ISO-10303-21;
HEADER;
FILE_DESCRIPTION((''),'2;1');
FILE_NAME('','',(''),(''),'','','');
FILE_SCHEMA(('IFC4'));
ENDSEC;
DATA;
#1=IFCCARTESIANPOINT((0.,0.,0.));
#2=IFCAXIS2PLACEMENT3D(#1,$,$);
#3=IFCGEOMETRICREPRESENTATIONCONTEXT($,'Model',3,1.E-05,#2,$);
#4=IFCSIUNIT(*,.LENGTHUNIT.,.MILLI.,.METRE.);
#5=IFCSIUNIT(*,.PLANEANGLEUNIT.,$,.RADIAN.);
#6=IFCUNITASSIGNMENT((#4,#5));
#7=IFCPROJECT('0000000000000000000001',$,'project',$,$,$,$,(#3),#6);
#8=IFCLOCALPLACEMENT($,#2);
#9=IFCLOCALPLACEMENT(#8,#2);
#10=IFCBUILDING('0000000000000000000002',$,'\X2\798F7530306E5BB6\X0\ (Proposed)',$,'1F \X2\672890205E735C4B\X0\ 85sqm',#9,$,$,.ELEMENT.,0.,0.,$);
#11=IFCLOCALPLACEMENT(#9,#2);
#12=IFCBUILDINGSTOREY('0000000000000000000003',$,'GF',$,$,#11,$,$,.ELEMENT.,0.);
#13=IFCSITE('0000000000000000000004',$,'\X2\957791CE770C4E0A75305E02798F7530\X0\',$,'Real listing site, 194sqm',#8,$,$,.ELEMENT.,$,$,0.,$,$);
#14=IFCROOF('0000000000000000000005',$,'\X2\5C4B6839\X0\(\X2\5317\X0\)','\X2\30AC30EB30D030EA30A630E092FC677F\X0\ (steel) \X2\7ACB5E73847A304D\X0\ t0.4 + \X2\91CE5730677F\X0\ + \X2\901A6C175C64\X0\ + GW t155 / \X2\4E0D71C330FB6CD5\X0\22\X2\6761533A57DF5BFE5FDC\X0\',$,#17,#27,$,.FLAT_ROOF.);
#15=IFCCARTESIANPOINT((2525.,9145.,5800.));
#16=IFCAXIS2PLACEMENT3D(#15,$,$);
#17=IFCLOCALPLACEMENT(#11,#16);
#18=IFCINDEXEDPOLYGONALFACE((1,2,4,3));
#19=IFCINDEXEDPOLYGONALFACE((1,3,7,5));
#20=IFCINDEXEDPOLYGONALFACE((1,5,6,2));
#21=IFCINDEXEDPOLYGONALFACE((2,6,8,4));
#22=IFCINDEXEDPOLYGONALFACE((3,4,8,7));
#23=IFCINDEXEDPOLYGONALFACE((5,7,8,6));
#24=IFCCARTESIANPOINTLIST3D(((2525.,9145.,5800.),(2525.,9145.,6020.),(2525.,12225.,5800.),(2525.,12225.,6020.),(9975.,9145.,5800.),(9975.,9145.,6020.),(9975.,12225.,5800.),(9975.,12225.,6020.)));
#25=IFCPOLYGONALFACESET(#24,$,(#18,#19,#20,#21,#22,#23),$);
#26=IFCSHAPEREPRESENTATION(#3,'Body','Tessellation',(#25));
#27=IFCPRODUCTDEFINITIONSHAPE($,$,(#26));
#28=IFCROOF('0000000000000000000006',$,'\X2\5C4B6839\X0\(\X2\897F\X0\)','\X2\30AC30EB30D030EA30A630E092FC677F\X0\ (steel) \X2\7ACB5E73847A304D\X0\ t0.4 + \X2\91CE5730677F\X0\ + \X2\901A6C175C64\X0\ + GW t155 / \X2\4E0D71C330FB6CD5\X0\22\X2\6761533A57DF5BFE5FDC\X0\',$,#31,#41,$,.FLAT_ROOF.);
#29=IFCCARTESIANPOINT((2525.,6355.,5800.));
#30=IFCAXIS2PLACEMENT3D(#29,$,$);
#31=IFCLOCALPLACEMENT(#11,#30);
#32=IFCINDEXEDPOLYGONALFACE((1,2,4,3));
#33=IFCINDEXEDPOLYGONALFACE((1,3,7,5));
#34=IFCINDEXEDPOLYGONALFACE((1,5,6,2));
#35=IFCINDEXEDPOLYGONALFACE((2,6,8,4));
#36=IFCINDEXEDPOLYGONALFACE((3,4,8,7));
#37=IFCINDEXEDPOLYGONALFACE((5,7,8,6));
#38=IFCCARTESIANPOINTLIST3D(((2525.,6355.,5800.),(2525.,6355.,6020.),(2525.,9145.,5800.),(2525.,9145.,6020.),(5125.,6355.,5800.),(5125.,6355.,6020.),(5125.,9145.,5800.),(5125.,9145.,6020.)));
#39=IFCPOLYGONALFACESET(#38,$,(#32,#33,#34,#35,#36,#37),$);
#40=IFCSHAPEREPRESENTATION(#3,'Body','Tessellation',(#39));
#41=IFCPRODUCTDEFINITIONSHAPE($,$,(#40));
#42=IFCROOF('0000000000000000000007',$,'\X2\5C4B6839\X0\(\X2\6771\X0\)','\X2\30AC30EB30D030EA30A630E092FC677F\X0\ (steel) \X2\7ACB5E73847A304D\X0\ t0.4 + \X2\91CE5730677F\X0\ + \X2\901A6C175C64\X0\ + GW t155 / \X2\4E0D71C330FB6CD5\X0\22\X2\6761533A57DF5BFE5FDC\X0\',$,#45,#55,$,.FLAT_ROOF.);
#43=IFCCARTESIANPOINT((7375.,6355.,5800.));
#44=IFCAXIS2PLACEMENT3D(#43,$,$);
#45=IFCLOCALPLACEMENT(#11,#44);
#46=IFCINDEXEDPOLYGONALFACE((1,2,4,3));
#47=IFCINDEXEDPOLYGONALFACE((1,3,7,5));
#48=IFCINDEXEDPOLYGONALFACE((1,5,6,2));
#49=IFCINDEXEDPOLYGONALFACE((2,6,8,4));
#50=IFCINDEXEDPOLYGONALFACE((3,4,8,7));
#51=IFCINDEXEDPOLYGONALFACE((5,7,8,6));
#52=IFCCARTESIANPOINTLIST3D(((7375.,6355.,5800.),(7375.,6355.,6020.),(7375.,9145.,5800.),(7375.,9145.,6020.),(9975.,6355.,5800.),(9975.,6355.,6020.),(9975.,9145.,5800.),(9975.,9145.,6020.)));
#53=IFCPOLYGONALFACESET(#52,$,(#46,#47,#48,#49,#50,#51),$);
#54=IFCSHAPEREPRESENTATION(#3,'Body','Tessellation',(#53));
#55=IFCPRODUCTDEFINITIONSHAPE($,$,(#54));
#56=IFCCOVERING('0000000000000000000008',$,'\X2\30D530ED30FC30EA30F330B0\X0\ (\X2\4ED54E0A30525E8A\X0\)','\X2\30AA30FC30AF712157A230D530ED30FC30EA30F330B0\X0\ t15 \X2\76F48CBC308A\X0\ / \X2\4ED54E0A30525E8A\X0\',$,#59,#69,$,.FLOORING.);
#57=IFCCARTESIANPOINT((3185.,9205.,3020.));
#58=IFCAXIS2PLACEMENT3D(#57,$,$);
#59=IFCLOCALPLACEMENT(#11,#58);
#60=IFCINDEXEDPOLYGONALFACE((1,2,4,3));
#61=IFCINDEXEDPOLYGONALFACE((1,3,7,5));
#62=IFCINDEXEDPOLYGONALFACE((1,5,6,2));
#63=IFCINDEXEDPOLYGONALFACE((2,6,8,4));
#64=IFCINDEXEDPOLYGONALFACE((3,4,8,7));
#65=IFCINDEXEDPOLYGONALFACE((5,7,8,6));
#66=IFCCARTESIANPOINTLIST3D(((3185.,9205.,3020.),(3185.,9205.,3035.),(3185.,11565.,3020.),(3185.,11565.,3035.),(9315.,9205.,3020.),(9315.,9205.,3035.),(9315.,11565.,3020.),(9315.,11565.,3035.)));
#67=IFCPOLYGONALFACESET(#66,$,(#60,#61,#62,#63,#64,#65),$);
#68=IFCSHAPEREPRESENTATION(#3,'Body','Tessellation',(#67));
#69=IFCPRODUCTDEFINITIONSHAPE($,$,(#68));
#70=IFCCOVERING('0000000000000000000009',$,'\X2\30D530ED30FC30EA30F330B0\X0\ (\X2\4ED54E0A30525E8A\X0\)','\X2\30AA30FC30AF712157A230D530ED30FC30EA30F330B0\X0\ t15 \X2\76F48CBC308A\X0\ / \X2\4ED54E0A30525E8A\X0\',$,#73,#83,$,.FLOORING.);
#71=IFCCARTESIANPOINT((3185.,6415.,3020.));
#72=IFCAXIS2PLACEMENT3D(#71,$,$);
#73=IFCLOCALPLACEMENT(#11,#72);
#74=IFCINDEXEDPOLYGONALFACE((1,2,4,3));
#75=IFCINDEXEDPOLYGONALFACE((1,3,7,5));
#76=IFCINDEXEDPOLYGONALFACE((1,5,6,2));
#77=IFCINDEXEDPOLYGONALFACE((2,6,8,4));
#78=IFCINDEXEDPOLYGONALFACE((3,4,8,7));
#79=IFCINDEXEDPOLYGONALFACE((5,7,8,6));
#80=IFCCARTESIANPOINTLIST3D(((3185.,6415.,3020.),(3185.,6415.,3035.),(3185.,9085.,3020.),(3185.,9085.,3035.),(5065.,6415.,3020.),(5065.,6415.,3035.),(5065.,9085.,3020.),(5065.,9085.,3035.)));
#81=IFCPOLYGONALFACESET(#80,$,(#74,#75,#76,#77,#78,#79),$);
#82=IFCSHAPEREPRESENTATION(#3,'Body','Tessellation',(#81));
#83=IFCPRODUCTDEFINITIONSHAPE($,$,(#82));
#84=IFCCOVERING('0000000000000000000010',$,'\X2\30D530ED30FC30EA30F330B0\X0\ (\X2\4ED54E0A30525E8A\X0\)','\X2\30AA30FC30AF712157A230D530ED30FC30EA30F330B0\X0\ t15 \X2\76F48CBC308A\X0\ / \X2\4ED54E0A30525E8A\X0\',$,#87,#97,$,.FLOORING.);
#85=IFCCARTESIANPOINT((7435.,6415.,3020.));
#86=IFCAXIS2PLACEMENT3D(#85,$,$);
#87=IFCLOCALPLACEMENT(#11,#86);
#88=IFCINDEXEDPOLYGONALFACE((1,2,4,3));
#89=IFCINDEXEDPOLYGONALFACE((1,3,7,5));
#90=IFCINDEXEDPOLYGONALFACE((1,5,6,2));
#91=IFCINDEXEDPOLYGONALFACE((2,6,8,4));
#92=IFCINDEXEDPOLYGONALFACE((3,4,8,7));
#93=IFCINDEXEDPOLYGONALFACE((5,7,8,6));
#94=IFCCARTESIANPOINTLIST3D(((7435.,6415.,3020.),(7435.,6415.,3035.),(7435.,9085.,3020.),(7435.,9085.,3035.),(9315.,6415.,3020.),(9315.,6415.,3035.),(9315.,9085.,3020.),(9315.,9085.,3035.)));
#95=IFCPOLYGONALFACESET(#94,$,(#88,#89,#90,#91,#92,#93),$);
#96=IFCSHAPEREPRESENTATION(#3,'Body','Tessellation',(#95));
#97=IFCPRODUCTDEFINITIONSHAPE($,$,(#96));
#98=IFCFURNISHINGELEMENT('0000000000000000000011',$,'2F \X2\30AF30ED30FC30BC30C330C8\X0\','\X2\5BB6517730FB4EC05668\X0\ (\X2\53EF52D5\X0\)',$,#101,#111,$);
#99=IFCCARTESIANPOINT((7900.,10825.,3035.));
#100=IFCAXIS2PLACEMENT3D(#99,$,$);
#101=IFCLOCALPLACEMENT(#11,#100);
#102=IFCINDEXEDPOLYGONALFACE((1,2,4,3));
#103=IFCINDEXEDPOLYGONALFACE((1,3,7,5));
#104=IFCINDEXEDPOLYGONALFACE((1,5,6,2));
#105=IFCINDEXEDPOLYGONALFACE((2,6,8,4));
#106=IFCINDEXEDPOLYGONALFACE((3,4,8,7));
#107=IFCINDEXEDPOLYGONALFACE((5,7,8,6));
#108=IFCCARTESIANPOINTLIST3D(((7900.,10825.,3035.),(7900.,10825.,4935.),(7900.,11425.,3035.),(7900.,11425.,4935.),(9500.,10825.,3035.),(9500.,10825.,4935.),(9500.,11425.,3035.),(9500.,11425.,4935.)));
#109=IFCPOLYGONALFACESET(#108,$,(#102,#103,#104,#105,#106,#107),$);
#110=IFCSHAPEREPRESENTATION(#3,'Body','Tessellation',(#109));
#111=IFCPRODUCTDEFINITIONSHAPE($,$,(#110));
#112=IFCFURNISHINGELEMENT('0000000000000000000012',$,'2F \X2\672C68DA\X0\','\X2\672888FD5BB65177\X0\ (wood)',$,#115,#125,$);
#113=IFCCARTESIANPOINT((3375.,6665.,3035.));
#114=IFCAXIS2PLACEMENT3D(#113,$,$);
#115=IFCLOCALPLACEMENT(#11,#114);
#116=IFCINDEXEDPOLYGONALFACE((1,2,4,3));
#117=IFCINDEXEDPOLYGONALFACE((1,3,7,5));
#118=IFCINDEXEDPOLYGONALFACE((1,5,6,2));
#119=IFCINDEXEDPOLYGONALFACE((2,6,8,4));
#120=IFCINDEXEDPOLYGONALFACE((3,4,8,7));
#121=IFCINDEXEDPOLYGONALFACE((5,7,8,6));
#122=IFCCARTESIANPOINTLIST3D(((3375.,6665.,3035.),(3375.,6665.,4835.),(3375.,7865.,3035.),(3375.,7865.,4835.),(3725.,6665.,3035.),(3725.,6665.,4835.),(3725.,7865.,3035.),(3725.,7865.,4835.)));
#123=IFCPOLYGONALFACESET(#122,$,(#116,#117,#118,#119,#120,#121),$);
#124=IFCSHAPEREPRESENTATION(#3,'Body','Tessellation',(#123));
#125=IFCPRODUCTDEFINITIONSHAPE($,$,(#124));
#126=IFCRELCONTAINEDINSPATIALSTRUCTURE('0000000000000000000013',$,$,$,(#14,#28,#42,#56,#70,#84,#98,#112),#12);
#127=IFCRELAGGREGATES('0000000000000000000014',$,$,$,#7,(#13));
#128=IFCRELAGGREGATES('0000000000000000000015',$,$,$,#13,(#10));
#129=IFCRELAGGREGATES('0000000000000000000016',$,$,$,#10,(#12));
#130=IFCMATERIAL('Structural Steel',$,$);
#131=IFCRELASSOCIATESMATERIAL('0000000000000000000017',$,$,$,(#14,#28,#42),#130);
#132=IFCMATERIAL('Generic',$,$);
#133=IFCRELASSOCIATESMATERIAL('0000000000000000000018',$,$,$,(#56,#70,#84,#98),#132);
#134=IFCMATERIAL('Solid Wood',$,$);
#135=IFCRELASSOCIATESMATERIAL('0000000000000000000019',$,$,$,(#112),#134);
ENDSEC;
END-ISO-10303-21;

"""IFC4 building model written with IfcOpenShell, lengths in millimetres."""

from ifc_helpers import new_model, si_unit, frame, frame_2d, origin, place, context, project, spatial, rectangle, extrude, material, element, save


model = new_model("IFC4")

# Units and contexts
model_context = context("Model", 3, precision=1e-05, world=origin())
ifc_project = project(units=[si_unit("LENGTHUNIT", "METRE", prefix="MILLI"), si_unit("PLANEANGLEUNIT", "RADIAN")], contexts=[model_context])

# Site, building, storey
site_placement = place(None, origin())
site = spatial("IfcSite", under=ifc_project, at=site_placement, Name="長野県上田市福田", ObjectType="Real listing site, 194sqm", CompositionType="ELEMENT", RefElevation=0.0)
building_placement = place(site_placement, origin())
building = spatial("IfcBuilding", under=site, at=building_placement, Name="福田の家 (Proposed)", ObjectType="1F 木造平屋 85sqm", CompositionType="ELEMENT", ElevationOfRefHeight=0.0, ElevationOfTerrain=0.0)
storey_placement = place(building_placement, origin())
storey = spatial("IfcBuildingStorey", under=building, at=storey_placement, Name="GF", CompositionType="ELEMENT", Elevation=0.0)

# Shared definitions
ifc_material_1 = material(Name="Solid Wood")

# Shared definitions
ifc_material_2 = material(Name="Generic")

# Roofs
ifc_material_3 = material(Name="Structural Steel")
for number, where, name in (
    (1, (2525.0, 9145.0, 5800.0), "屋根(北)"),
):
    element("IfcRoof", number, at=place(storey_placement, frame(where)), inside=storey, material=ifc_material_3, Name=name, Description="ガルバリウム鋼板 (steel) 立平葺き t0.4 + 野地板 + 通気層 + GW t155 / 不燃・法22条区域対応", PredefinedType="FLAT_ROOF", context=model_context, shape_type="SweptSolid", body=[
        extrude(rectangle(XDim=7450.0, YDim=3080.0, at=frame_2d((3725.0, 1540.0))), frame((2525.0, 9145.0, 5800.0)), (0.0, 0.0, 1.0), 220.0),
    ])
roof_1_placement = place(storey_placement, frame((2525.0, 6355.0, 5800.0)))
element("IfcRoof", 2, at=roof_1_placement, inside=storey, material=ifc_material_3, Name="屋根(西)", Description="ガルバリウム鋼板 (steel) 立平葺き t0.4 + 野地板 + 通気層 + GW t155 / 不燃・法22条区域対応", PredefinedType="FLAT_ROOF", context=model_context, shape_type="SweptSolid", body=[
    extrude(rectangle(XDim=2600.0, YDim=2790.0, at=frame_2d((1300.0, 1395.0))), frame((2525.0, 6355.0, 5800.0)), (0.0, 0.0, 1.0), 220.0),
])
roof_2_placement = place(storey_placement, frame((7375.0, 6355.0, 5800.0)))
element("IfcRoof", 3, at=roof_2_placement, inside=storey, material=ifc_material_3, Name="屋根(東)", Description="ガルバリウム鋼板 (steel) 立平葺き t0.4 + 野地板 + 通気層 + GW t155 / 不燃・法22条区域対応", PredefinedType="FLAT_ROOF", context=model_context, shape_type="SweptSolid", body=[
    extrude(rectangle(XDim=2600.0, YDim=2790.0, at=frame_2d((1300.0, 1395.0))), frame((7375.0, 6355.0, 5800.0)), (0.0, 0.0, 1.0), 220.0),
])

# Coverings
covering_1_placement = place(storey_placement, frame((3185.0, 9205.0, 3020.0)))
element("IfcCovering", 4, at=covering_1_placement, inside=storey, material=ifc_material_2, Name="フローリング (仕上げ床)", Description="オーク無垢フローリング t15 直貼り / 仕上げ床", PredefinedType="FLOORING", context=model_context, shape_type="SweptSolid", body=[
    extrude(rectangle(XDim=6130.0, YDim=2360.0, at=frame_2d((3065.0, 1180.0))), frame((3185.0, 9205.0, 3020.0)), (0.0, 0.0, 1.0), 15.0),
])
covering_2_placement = place(storey_placement, frame((3185.0, 6415.0, 3020.0)))
element("IfcCovering", 5, at=covering_2_placement, inside=storey, material=ifc_material_2, Name="フローリング (仕上げ床)", Description="オーク無垢フローリング t15 直貼り / 仕上げ床", PredefinedType="FLOORING", context=model_context, shape_type="SweptSolid", body=[
    extrude(rectangle(XDim=1880.0, YDim=2670.0, at=frame_2d((940.0, 1335.0))), frame((3185.0, 6415.0, 3020.0)), (0.0, 0.0, 1.0), 15.0),
])
covering_3_placement = place(storey_placement, frame((7435.0, 6415.0, 3020.0)))
element("IfcCovering", 6, at=covering_3_placement, inside=storey, material=ifc_material_2, Name="フローリング (仕上げ床)", Description="オーク無垢フローリング t15 直貼り / 仕上げ床", PredefinedType="FLOORING", context=model_context, shape_type="SweptSolid", body=[
    extrude(rectangle(XDim=1880.0, YDim=2670.0, at=frame_2d((940.0, 1335.0))), frame((7435.0, 6415.0, 3020.0)), (0.0, 0.0, 1.0), 15.0),
])

# Furnishing elements
furnishing_1_placement = place(storey_placement, frame((7900.0, 10825.0, 3035.0)))
element("IfcFurnishingElement", 7, at=furnishing_1_placement, inside=storey, material=ifc_material_2, Name="2F クローゼット", Description="家具・什器 (可動)", context=model_context, shape_type="SweptSolid", body=[
    extrude(rectangle(XDim=1600.0, YDim=600.0, at=frame_2d((800.0, 300.0))), frame((7900.0, 10825.0, 3035.0)), (0.0, 0.0, 1.0), 1900.0),
])
furnishing_2_placement = place(storey_placement, frame((3375.0, 6665.0, 3035.0)))
element("IfcFurnishingElement", 8, at=furnishing_2_placement, inside=storey, material=ifc_material_1, Name="2F 本棚", Description="木製家具 (wood)", context=model_context, shape_type="SweptSolid", body=[
    extrude(rectangle(XDim=350.0, YDim=1200.0, at=frame_2d((175.0, 600.0))), frame((3375.0, 6665.0, 3035.0)), (0.0, 0.0, 1.0), 1800.0),
])

save(model, "model.ifc")
